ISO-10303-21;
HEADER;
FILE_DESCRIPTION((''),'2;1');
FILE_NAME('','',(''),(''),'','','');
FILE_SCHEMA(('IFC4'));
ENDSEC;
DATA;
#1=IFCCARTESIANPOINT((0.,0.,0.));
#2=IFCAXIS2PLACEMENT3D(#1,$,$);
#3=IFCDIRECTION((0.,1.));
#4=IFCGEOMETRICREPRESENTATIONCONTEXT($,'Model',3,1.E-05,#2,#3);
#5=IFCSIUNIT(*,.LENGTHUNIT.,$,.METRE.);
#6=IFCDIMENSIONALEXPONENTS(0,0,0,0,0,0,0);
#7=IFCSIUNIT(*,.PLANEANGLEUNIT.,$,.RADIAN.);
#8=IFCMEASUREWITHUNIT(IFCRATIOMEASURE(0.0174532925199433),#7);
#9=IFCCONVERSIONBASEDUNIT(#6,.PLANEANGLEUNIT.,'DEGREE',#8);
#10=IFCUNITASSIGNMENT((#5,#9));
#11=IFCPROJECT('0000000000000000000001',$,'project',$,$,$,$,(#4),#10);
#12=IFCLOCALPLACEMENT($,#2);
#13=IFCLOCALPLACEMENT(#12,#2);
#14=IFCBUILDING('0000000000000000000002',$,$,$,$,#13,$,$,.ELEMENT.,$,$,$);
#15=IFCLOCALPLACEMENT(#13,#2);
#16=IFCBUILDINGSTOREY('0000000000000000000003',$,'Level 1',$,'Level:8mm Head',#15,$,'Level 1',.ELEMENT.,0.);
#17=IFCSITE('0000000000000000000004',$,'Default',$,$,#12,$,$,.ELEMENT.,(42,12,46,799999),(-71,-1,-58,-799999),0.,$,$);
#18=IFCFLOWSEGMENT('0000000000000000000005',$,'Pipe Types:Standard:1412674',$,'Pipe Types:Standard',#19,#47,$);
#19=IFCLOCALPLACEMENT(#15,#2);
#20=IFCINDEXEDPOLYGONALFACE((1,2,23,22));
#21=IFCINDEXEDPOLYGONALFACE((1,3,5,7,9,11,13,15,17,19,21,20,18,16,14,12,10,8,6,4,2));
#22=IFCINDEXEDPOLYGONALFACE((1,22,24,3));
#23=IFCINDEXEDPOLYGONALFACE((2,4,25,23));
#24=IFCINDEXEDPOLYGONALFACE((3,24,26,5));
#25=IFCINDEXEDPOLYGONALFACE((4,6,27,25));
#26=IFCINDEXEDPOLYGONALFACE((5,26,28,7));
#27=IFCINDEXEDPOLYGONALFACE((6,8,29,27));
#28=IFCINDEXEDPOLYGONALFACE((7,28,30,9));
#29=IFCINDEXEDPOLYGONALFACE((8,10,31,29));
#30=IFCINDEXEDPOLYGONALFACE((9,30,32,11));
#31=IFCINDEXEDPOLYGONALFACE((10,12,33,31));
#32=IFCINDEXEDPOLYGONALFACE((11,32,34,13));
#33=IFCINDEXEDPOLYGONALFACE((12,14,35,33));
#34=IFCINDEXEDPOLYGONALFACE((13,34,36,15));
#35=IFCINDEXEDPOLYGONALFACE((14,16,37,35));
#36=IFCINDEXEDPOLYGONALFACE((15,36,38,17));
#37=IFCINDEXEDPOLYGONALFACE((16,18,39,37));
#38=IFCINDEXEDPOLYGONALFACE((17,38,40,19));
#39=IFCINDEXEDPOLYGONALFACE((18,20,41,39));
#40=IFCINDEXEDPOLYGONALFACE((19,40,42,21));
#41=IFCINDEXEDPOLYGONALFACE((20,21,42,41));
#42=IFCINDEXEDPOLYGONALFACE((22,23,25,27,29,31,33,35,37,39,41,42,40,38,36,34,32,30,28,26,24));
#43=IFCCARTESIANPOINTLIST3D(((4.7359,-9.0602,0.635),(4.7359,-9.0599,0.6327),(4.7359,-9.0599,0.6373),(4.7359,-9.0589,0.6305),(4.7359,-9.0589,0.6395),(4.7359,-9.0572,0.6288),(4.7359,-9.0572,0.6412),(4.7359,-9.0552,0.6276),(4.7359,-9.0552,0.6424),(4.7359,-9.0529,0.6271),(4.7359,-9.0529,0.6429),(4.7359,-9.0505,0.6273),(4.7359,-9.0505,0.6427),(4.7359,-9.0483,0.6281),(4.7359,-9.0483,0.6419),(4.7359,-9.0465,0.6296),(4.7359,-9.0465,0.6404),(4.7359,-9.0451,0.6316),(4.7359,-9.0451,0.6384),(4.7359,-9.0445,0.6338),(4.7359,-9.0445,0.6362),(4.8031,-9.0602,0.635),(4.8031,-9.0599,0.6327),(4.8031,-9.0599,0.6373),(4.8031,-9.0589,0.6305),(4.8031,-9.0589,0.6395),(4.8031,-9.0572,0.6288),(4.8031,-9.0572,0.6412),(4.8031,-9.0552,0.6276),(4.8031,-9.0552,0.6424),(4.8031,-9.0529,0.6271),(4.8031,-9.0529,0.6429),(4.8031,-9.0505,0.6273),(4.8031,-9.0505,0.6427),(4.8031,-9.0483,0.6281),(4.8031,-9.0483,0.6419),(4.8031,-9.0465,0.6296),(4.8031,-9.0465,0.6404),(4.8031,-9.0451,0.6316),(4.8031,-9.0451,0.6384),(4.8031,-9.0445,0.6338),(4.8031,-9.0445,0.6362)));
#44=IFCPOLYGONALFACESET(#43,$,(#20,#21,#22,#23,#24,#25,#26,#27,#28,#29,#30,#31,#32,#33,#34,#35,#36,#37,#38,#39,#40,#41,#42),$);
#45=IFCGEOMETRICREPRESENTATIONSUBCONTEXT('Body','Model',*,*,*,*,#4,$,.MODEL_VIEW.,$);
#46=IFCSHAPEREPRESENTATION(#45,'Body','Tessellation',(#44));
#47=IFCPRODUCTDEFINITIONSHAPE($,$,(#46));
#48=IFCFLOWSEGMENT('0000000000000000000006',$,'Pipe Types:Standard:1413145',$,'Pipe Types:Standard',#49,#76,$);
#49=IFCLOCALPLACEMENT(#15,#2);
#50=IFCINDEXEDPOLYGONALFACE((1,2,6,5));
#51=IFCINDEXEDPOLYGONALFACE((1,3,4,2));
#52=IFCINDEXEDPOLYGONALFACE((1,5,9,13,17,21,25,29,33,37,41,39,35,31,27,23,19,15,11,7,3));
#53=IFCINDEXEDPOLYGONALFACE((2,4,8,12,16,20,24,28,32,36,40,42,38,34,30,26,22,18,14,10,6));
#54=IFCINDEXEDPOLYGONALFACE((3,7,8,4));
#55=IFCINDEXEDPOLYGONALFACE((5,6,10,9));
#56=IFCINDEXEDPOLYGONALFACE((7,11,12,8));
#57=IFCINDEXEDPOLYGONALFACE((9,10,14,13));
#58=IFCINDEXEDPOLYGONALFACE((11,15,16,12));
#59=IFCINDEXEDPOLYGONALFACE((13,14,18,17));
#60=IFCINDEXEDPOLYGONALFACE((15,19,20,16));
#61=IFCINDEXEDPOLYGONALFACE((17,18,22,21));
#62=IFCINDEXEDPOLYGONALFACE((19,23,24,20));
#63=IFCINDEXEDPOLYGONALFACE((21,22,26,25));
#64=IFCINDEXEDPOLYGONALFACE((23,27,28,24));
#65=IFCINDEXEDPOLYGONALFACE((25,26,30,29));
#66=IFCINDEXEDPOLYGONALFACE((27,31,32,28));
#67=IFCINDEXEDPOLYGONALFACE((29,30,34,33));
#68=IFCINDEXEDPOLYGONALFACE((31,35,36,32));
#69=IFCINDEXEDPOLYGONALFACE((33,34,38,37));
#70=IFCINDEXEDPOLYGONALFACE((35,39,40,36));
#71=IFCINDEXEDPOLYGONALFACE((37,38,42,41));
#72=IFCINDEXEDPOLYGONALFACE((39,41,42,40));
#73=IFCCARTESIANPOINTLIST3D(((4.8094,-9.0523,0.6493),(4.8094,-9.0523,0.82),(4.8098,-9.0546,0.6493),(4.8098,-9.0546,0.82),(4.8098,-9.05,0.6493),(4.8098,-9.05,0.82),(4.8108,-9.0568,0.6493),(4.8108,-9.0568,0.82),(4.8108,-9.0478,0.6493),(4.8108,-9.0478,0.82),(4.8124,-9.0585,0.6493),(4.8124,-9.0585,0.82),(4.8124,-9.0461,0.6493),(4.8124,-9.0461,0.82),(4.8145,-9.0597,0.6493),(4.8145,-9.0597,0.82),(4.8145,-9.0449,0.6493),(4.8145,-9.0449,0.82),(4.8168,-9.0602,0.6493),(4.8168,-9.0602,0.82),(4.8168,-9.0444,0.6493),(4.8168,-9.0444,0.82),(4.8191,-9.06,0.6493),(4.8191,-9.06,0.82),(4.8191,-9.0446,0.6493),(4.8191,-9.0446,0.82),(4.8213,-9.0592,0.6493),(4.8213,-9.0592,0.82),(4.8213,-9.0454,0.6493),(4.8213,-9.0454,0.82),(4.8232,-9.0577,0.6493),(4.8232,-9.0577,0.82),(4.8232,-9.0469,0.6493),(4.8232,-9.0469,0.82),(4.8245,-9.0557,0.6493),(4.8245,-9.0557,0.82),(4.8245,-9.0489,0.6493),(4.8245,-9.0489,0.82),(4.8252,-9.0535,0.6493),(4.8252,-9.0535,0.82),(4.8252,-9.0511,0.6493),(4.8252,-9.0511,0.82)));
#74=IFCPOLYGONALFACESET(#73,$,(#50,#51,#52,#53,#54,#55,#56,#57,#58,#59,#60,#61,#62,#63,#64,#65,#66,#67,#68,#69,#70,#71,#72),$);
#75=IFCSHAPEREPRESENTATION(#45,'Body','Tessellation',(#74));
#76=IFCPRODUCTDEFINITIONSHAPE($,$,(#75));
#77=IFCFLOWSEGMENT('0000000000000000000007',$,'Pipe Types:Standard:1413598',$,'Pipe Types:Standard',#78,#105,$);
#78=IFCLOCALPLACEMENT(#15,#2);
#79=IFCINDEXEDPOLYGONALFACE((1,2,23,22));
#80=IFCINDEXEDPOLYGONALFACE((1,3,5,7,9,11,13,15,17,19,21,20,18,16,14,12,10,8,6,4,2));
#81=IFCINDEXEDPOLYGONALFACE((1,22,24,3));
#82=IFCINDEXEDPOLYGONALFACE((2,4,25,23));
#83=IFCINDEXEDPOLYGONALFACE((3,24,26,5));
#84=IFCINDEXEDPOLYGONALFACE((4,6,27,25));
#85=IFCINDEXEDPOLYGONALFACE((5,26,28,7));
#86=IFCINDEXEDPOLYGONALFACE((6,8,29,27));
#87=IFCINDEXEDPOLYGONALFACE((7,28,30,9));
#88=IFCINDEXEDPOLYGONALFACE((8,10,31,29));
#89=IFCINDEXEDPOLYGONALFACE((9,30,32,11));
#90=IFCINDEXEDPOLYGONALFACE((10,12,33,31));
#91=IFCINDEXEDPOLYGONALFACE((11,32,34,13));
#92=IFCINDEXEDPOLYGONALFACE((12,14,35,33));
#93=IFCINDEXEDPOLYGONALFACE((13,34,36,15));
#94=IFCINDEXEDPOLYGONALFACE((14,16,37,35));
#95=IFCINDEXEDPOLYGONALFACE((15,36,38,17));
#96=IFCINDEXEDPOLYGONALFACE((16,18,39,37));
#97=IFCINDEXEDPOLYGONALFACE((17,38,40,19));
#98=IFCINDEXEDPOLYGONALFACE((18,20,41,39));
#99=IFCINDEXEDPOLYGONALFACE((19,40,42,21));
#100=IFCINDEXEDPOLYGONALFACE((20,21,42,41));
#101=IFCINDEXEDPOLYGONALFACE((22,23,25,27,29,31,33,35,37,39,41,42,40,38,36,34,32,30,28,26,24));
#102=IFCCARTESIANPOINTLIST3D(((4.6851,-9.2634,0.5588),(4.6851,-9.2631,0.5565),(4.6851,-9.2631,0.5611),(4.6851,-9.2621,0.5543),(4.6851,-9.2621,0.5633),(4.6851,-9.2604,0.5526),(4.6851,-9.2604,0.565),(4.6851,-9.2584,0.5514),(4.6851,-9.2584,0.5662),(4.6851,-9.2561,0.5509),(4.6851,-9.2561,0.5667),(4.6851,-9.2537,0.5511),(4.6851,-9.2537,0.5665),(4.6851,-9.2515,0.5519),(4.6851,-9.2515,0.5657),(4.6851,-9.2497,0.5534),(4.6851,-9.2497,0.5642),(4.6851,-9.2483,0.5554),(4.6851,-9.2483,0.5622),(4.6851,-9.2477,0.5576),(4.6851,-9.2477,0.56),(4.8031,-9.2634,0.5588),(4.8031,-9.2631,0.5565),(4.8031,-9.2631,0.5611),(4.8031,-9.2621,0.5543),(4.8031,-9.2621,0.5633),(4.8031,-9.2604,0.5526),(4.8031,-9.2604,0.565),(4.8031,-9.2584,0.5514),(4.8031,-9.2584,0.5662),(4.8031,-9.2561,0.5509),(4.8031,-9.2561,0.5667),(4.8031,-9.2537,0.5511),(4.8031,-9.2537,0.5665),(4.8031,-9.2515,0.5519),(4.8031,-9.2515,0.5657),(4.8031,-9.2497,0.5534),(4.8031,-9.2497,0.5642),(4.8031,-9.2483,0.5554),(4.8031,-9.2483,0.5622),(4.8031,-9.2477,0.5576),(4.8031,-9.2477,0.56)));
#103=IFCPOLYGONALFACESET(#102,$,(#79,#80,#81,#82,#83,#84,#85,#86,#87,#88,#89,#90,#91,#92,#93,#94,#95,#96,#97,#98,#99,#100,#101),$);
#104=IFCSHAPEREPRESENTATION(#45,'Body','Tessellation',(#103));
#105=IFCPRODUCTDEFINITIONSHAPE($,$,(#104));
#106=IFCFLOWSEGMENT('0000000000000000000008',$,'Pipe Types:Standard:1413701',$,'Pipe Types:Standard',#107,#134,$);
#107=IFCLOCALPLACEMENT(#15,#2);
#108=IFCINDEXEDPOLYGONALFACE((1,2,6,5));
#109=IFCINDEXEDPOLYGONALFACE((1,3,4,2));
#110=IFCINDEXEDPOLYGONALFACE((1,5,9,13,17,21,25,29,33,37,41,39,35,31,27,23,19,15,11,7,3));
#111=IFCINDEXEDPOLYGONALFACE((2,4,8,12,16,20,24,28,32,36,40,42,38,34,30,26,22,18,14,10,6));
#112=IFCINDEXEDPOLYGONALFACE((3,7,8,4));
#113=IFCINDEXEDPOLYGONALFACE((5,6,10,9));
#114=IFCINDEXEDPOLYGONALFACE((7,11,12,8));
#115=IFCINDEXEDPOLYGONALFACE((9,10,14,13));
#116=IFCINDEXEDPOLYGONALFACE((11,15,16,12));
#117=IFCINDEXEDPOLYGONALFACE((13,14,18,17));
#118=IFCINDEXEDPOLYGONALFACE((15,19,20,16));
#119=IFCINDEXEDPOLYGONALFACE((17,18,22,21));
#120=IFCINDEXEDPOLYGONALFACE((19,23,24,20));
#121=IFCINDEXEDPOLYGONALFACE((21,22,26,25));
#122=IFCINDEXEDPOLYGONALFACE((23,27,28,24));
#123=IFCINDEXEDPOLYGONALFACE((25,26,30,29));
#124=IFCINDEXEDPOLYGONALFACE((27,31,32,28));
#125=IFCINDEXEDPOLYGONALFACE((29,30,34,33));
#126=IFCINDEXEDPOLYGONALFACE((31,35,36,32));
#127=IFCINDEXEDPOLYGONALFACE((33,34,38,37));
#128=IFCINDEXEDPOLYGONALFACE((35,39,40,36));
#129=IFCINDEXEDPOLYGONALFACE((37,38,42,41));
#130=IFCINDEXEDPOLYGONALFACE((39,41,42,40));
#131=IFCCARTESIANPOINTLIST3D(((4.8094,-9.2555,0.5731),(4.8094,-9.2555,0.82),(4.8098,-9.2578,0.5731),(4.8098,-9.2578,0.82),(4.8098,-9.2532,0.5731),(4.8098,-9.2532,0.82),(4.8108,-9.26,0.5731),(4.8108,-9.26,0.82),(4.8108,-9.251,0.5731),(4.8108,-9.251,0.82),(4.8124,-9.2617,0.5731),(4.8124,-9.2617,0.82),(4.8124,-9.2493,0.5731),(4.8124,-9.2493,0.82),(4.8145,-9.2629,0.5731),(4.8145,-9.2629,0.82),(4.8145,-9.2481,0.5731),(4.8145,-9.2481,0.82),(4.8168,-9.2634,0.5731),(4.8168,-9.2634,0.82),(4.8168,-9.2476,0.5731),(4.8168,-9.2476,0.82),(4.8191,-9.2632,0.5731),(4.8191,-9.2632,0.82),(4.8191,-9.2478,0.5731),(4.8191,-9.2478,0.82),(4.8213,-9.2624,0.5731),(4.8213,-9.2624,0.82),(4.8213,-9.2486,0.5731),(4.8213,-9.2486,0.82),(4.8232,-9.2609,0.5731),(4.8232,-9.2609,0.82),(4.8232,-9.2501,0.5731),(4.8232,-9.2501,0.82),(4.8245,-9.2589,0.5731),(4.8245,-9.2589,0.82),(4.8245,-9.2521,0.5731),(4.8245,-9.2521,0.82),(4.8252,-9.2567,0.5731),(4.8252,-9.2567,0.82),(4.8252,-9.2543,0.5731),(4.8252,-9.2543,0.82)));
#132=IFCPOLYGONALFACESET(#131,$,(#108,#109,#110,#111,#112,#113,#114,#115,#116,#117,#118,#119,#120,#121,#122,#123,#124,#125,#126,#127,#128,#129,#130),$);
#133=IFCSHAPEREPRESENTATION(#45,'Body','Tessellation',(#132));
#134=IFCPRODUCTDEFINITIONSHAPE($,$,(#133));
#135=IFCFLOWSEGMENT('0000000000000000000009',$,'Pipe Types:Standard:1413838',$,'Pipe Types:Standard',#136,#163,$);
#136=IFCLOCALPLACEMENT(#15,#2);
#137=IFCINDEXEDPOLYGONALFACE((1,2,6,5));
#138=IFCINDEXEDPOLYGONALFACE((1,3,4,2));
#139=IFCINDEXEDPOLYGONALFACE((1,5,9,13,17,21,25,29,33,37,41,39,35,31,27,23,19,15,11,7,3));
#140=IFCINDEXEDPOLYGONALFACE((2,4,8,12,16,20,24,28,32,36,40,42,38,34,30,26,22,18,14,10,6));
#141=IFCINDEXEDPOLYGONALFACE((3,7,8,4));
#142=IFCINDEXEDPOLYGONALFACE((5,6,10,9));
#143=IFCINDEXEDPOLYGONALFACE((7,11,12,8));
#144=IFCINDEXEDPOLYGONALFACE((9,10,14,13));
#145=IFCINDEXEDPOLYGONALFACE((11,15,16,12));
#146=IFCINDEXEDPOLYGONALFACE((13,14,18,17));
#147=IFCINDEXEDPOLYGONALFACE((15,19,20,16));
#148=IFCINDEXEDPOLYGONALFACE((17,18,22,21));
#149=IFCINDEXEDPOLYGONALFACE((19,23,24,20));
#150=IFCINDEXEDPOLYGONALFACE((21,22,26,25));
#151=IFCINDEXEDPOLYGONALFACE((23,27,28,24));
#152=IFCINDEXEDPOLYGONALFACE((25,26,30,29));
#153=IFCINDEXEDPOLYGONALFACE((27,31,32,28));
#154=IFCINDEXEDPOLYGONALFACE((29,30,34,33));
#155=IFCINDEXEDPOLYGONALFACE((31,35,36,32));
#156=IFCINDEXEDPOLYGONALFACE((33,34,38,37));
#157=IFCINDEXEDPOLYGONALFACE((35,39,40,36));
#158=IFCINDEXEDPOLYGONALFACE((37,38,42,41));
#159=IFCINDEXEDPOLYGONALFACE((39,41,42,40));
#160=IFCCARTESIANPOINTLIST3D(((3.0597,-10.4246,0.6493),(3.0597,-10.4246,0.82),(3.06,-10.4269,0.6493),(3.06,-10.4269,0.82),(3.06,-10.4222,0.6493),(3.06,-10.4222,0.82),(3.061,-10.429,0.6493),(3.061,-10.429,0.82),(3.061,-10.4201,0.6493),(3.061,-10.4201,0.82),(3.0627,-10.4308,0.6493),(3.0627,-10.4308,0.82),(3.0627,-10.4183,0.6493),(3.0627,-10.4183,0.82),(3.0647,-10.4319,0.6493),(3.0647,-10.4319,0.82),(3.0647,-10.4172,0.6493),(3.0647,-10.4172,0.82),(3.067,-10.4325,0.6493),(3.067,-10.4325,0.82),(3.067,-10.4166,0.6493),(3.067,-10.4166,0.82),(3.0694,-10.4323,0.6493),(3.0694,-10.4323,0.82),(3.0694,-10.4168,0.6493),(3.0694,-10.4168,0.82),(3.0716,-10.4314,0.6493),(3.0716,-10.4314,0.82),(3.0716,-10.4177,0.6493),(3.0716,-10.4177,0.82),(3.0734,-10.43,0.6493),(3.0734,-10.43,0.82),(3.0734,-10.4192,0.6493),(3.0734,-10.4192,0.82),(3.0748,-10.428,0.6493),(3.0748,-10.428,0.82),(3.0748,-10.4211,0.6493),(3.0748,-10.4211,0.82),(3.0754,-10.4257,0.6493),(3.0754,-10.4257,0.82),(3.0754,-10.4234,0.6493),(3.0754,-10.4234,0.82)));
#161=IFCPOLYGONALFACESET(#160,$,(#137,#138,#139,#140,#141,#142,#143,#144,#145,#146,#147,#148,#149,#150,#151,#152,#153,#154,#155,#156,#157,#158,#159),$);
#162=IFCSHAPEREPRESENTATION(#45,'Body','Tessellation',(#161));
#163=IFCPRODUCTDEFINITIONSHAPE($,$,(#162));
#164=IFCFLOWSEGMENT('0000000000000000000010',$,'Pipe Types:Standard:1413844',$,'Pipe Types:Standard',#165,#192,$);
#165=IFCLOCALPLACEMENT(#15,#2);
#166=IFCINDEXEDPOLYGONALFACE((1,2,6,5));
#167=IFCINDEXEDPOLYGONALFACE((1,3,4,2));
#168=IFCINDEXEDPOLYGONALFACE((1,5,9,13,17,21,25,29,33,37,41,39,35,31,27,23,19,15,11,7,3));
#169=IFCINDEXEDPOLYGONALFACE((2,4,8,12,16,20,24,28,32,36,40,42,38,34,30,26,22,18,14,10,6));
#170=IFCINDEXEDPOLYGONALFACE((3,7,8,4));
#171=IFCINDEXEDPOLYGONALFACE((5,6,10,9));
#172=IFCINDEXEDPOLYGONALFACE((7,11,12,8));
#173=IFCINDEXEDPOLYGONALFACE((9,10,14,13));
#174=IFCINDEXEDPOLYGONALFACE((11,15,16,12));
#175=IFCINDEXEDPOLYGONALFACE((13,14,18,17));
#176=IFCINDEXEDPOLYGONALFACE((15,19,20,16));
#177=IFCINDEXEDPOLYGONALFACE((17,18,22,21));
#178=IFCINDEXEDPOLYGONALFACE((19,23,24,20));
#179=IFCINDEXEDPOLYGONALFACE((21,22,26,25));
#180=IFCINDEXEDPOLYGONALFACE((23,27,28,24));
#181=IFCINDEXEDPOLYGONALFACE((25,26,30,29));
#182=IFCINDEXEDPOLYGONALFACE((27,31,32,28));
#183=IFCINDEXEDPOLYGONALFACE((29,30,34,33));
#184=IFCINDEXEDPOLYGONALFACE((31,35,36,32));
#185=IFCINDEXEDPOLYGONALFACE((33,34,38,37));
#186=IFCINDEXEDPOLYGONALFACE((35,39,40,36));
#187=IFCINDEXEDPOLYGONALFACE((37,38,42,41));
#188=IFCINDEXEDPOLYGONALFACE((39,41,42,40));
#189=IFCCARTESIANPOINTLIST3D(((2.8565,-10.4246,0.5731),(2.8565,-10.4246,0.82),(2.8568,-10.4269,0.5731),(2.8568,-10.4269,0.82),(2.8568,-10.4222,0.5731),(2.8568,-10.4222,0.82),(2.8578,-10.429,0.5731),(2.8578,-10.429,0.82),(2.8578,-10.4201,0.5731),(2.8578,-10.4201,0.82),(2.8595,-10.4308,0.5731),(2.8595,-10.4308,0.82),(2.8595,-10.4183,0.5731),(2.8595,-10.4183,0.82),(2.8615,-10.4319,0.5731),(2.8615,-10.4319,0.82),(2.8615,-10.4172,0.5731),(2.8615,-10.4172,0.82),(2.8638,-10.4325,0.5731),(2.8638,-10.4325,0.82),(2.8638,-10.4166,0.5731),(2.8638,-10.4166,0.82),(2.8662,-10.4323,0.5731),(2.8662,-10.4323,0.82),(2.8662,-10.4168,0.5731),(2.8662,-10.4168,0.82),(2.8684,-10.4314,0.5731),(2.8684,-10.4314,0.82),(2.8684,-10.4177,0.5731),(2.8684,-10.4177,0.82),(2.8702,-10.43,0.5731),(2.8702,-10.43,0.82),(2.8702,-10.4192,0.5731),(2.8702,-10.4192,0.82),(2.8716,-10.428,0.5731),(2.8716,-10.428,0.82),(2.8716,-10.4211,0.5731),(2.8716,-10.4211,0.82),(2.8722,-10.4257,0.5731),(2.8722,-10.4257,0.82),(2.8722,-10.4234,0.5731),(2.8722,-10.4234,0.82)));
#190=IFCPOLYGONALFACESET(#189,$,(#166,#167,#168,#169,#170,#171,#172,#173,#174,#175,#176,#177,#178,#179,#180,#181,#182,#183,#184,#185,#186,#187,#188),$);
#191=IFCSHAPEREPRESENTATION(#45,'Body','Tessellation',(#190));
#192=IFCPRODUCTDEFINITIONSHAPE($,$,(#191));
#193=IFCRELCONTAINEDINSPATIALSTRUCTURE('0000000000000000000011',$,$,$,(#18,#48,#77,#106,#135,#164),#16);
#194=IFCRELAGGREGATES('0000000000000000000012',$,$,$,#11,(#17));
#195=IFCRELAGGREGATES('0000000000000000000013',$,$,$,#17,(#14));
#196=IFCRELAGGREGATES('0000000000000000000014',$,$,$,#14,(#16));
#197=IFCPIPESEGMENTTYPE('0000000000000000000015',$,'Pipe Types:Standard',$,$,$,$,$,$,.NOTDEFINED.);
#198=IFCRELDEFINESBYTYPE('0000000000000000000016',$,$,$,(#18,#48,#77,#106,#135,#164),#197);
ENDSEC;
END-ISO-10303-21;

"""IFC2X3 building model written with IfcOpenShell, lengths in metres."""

from ifc_helpers import new_model, entity, si_unit, converted_unit, direction, frame, origin, origin_2d_with_axis, place, context, subcontext, project, spatial, circle, extrude, type_object, element, save


model = new_model("IFC2X3")

# Units and contexts
model_context = context("Model", 3, precision=1e-05, world=origin(), true_north=direction((0.0, 1.0)))
body_context = subcontext(model_context, "Body", "Model", "MODEL_VIEW")
ifc_project = project(units=[si_unit("LENGTHUNIT", "METRE"), converted_unit("PLANEANGLEUNIT", "DEGREE", entity("IfcRatioMeasure", 0.0174532925199433), si_unit("PLANEANGLEUNIT", "RADIAN"), dimensions=[0, 0, 0, 0, 0, 0, 0])], contexts=[model_context])

# Site, building, storey
site_placement = place(None, origin())
site = spatial("IfcSite", under=ifc_project, at=site_placement, Name="Default", CompositionType="ELEMENT", RefLatitude=(42, 12, 46, 799999), RefLongitude=(-71, -1, -58, -799999), RefElevation=0.0)
building_placement = place(site_placement, origin())
building = spatial("IfcBuilding", under=site, at=building_placement, CompositionType="ELEMENT")
storey_placement = place(building_placement, origin())
storey = spatial("IfcBuildingStorey", under=building, at=storey_placement, Name="Level 1", ObjectType="Level:8mm Head", LongName="Level 1", CompositionType="ELEMENT", Elevation=0.0)

# Flow segments
pipe_segment_type = type_object("IfcPipeSegmentType", Name="Pipe Types:Standard", PredefinedType="NOTDEFINED")
flow_segment_1_placement = place(storey_placement, origin())
element("IfcFlowSegment", 1, at=flow_segment_1_placement, inside=storey, type_object=pipe_segment_type, Name="Pipe Types:Standard:1412674", ObjectType="Pipe Types:Standard", context=body_context, shape_type="SweptSolid", body=[
    extrude(circle(Radius=0.0079, at=origin_2d_with_axis()), frame((4.7359, -9.0523, 0.635), z_axis=(1.0, 0.0, 0.0), x_axis=(0.0, -1.0, 0.0)), (0.0, 0.0, 1.0), 0.0672),
])
flow_segment_2_placement = place(storey_placement, origin())
element("IfcFlowSegment", 2, at=flow_segment_2_placement, inside=storey, type_object=pipe_segment_type, Name="Pipe Types:Standard:1413145", ObjectType="Pipe Types:Standard", context=body_context, shape_type="SweptSolid", body=[
    extrude(circle(Radius=0.0079, at=origin_2d_with_axis()), frame((4.8174, -9.0523, 0.6493), z_axis=(0.0, 0.0, 1.0), x_axis=(-1.0, 0.0, 0.0)), (0.0, 0.0, 1.0), 0.1707),
])
flow_segment_3_placement = place(storey_placement, origin())
element("IfcFlowSegment", 3, at=flow_segment_3_placement, inside=storey, type_object=pipe_segment_type, Name="Pipe Types:Standard:1413598", ObjectType="Pipe Types:Standard", context=body_context, shape_type="SweptSolid", body=[
    extrude(circle(Radius=0.0079, at=origin_2d_with_axis()), frame((4.6851, -9.2555, 0.5588), z_axis=(1.0, 0.0, 0.0), x_axis=(0.0, -1.0, 0.0)), (0.0, 0.0, 1.0), 0.118),
])
flow_segment_4_placement = place(storey_placement, origin())
element("IfcFlowSegment", 4, at=flow_segment_4_placement, inside=storey, type_object=pipe_segment_type, Name="Pipe Types:Standard:1413701", ObjectType="Pipe Types:Standard", context=body_context, shape_type="SweptSolid", body=[
    extrude(circle(Radius=0.0079, at=origin_2d_with_axis()), frame((4.8174, -9.2555, 0.5731), z_axis=(0.0, 0.0, 1.0), x_axis=(-1.0, 0.0, 0.0)), (0.0, 0.0, 1.0), 0.2469),
])
flow_segment_5_placement = place(storey_placement, origin())
element("IfcFlowSegment", 5, at=flow_segment_5_placement, inside=storey, type_object=pipe_segment_type, Name="Pipe Types:Standard:1413838", ObjectType="Pipe Types:Standard", context=body_context, shape_type="SweptSolid", body=[
    extrude(circle(Radius=0.0079, at=origin_2d_with_axis()), frame((3.0676, -10.4246, 0.6493), z_axis=(0.0, 0.0, 1.0), x_axis=(-1.0, 0.0, 0.0)), (0.0, 0.0, 1.0), 0.1707),
])
flow_segment_6_placement = place(storey_placement, origin())
element("IfcFlowSegment", 6, at=flow_segment_6_placement, inside=storey, type_object=pipe_segment_type, Name="Pipe Types:Standard:1413844", ObjectType="Pipe Types:Standard", context=body_context, shape_type="SweptSolid", body=[
    extrude(circle(Radius=0.0079, at=origin_2d_with_axis()), frame((2.8644, -10.4246, 0.5731), z_axis=(0.0, 0.0, 1.0), x_axis=(-1.0, 0.0, 0.0)), (0.0, 0.0, 1.0), 0.2469),
])

save(model, "model.ifc")
